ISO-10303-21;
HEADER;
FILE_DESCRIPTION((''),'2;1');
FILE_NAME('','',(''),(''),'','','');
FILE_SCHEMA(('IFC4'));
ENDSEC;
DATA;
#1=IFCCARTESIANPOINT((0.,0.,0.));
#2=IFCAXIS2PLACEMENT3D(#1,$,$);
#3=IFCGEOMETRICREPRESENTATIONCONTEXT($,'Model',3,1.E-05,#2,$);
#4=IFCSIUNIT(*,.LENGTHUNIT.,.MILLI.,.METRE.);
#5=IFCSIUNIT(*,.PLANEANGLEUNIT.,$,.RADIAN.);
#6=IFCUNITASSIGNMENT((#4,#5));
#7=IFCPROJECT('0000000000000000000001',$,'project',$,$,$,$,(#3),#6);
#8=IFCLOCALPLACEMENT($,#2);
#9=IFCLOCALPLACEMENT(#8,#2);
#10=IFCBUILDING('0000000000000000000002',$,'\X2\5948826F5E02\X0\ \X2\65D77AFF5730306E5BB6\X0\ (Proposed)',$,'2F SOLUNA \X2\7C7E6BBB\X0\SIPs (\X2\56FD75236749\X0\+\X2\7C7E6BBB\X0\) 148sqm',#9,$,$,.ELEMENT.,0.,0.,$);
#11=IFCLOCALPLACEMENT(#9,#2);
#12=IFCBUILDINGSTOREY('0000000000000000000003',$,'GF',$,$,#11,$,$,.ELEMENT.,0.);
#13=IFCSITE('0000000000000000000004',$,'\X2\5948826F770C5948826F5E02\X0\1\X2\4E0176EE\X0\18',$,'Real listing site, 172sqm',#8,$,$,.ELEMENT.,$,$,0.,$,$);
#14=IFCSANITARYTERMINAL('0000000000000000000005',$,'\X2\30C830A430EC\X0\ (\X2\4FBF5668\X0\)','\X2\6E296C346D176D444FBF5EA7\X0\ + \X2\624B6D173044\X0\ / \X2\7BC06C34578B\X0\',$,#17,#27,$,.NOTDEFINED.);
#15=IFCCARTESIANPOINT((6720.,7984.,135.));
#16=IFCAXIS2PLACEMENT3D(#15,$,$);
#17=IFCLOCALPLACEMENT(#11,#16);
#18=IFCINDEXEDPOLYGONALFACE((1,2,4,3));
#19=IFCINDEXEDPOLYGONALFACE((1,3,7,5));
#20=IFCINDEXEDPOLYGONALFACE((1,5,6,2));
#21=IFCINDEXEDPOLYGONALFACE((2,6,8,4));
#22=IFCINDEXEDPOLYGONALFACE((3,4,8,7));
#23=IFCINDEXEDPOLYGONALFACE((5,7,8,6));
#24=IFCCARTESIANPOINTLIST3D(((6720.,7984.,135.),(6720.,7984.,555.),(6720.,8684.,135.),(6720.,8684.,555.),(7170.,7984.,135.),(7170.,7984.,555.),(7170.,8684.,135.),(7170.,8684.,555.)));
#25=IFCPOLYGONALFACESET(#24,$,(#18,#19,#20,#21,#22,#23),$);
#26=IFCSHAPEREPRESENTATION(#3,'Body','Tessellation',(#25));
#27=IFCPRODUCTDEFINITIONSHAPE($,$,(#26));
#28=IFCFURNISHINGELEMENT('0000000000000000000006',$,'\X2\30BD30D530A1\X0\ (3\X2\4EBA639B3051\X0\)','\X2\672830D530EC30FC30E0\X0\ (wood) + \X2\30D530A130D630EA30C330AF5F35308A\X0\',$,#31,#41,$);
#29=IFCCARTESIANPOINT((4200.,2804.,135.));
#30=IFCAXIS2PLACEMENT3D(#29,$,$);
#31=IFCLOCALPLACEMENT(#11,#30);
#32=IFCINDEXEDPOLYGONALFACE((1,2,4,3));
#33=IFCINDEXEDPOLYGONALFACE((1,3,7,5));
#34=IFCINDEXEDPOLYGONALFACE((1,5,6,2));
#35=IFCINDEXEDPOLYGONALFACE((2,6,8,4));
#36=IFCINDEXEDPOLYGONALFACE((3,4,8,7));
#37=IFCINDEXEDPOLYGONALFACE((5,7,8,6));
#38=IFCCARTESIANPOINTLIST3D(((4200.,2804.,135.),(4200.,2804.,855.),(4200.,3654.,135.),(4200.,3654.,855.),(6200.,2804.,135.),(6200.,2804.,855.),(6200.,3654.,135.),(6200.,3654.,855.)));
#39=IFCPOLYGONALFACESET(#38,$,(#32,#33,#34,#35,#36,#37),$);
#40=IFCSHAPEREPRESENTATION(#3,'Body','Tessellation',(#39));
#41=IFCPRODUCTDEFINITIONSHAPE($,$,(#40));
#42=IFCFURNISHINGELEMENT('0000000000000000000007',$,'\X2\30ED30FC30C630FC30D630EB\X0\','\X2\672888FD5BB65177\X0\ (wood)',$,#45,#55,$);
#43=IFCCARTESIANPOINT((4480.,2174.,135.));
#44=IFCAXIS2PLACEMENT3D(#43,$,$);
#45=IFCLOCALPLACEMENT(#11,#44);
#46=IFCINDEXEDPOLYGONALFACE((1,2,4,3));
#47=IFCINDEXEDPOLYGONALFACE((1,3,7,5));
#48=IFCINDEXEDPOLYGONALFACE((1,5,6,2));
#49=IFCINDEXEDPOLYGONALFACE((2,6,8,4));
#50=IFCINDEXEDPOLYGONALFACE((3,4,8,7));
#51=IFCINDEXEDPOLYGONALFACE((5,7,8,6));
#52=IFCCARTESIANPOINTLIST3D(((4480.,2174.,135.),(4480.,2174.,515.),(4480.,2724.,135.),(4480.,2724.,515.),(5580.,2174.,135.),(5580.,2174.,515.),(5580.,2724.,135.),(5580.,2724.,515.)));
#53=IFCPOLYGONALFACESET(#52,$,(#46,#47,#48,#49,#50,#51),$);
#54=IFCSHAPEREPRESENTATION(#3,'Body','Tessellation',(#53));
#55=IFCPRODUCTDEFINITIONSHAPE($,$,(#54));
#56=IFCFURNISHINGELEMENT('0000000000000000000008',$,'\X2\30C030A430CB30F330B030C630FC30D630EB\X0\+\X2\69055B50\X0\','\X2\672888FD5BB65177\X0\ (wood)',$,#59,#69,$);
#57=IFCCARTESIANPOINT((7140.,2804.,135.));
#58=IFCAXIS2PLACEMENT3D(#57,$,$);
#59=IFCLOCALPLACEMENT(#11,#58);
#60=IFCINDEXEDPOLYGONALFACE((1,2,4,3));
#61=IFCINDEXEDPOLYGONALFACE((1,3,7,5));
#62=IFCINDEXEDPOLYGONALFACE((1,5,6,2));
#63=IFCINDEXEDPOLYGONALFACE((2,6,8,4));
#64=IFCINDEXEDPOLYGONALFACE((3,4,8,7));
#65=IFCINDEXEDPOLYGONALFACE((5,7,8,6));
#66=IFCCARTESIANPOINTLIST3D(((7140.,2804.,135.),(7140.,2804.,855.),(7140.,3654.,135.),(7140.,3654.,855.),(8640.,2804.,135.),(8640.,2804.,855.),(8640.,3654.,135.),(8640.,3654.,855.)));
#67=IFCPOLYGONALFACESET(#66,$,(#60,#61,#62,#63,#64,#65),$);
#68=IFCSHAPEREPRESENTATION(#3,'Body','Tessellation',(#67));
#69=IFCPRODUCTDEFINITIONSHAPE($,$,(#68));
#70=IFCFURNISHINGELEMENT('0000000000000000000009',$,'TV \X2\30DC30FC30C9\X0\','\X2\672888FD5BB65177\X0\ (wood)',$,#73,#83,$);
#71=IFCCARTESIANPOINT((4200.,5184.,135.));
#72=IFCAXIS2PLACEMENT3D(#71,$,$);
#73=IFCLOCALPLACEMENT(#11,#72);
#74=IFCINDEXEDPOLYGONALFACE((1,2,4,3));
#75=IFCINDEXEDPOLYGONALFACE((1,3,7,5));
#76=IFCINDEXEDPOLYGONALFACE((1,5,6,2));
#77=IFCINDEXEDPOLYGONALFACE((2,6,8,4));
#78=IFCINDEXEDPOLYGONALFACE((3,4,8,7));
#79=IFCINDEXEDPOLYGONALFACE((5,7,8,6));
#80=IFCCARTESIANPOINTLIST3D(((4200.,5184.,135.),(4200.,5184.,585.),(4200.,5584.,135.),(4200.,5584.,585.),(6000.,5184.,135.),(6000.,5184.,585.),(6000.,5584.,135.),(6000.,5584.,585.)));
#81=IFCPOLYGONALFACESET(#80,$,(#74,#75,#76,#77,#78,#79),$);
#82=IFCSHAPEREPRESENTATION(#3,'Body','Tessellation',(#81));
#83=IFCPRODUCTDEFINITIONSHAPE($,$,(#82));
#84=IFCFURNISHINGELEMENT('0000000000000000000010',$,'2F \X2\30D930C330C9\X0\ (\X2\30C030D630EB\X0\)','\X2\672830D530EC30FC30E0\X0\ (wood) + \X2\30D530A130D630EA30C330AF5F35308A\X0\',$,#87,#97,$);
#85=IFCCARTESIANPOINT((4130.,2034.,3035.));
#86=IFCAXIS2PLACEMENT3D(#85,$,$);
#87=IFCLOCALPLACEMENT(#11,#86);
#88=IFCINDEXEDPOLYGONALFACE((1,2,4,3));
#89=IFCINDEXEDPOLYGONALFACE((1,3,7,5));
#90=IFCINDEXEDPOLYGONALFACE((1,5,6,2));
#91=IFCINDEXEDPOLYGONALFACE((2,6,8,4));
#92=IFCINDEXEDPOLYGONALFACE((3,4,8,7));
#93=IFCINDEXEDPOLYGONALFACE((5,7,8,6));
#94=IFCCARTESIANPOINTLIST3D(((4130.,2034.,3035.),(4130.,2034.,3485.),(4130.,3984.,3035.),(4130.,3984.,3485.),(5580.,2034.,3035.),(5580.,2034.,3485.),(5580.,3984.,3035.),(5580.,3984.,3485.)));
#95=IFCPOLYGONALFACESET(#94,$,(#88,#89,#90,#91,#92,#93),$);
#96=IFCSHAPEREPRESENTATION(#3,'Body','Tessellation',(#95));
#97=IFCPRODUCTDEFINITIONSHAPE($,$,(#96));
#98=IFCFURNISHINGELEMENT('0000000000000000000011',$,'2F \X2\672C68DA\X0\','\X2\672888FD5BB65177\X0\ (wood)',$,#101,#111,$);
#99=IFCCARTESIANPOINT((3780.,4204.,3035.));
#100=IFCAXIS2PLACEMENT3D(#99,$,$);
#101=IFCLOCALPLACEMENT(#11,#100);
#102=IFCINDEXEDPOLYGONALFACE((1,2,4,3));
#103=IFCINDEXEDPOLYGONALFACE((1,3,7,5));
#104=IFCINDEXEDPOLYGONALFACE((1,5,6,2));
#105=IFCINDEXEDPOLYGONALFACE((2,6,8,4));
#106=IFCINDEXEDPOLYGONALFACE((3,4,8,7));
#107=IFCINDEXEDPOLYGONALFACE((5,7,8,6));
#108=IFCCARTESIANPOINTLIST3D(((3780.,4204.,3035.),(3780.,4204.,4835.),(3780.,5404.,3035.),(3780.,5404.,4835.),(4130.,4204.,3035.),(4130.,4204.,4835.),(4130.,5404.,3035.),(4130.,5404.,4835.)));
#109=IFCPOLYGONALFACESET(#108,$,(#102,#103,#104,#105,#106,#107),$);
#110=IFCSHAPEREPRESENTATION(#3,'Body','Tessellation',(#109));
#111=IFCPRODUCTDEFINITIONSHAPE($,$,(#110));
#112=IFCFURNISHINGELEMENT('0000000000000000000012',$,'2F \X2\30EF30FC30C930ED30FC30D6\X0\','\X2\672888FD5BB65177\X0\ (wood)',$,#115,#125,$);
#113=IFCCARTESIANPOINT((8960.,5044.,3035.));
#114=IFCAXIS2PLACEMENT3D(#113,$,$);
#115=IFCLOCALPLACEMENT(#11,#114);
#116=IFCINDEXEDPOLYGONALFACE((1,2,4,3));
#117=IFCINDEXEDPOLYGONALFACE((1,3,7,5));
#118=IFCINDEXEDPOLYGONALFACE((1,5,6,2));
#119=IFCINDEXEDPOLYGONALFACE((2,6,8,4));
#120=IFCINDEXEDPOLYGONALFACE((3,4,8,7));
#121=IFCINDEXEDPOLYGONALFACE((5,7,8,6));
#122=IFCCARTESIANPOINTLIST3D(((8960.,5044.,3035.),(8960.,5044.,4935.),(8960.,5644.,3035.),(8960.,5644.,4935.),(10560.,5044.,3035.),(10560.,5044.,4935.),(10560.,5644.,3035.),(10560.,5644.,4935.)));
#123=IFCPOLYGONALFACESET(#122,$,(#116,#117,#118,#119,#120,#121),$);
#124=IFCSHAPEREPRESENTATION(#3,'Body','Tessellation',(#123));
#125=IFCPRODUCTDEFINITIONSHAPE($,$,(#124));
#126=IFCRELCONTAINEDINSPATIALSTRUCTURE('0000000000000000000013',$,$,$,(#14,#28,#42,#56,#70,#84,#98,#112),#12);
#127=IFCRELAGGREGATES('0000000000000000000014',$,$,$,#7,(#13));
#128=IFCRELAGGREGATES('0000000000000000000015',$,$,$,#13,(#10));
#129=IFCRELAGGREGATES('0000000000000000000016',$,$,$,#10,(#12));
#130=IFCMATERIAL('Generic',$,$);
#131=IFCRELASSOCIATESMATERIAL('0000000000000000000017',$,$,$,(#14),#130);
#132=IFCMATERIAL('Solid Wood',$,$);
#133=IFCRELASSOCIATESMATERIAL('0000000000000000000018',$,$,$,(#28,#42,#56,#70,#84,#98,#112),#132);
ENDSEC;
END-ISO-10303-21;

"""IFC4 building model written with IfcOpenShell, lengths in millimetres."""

from ifc_helpers import new_model, si_unit, frame, frame_2d, origin, place, context, project, spatial, rectangle, extrude, material, element, save


model = new_model("IFC4")

# Units and contexts
model_context = context("Model", 3, precision=1e-05, world=origin())
ifc_project = project(units=[si_unit("LENGTHUNIT", "METRE", prefix="MILLI"), si_unit("PLANEANGLEUNIT", "RADIAN")], contexts=[model_context])

# Site, building, storey
site_placement = place(None, origin())
site = spatial("IfcSite", under=ifc_project, at=site_placement, Name="奈良県奈良市1丁目18", ObjectType="Real listing site, 172sqm", CompositionType="ELEMENT", RefElevation=0.0)
building_placement = place(site_placement, origin())
building = spatial("IfcBuilding", under=site, at=building_placement, Name="奈良市 旗竿地の家 (Proposed)", ObjectType="2F SOLUNA 籾殻SIPs (国産杉+籾殻) 148sqm", CompositionType="ELEMENT", ElevationOfRefHeight=0.0, ElevationOfTerrain=0.0)
storey_placement = place(building_placement, origin())
storey = spatial("IfcBuildingStorey", under=building, at=storey_placement, Name="GF", CompositionType="ELEMENT", Elevation=0.0)

# Shared definitions
ifc_material_1 = material(Name="Solid Wood")

# Shared definitions
ifc_material_2 = material(Name="Generic")

# Sanitary terminal
sanitary_terminal_1_placement = place(storey_placement, frame((6720.0, 7984.0, 135.0)))
element("IfcSanitaryTerminal", 1, at=sanitary_terminal_1_placement, inside=storey, material=ifc_material_2, Name="トイレ (便器)", Description="温水洗浄便座 + 手洗い / 節水型", PredefinedType="NOTDEFINED", context=model_context, shape_type="SweptSolid", body=[
    extrude(rectangle(XDim=450.0, YDim=700.0, at=frame_2d((225.0, 350.0))), frame((6720.0, 7984.0, 135.0)), (0.0, 0.0, 1.0), 420.0),
])

# Furnishing elements
furnishing_1_placement = place(storey_placement, frame((4200.0, 2804.0, 135.0)))
element("IfcFurnishingElement", 2, at=furnishing_1_placement, inside=storey, material=ifc_material_1, Name="ソファ (3人掛け)", Description="木フレーム (wood) + ファブリック張り", context=model_context, shape_type="SweptSolid", body=[
    extrude(rectangle(XDim=2000.0, YDim=850.0, at=frame_2d((1000.0, 425.0))), frame((4200.0, 2804.0, 135.0)), (0.0, 0.0, 1.0), 720.0),
])
furnishing_2_placement = place(storey_placement, frame((4480.0, 2174.0, 135.0)))
element("IfcFurnishingElement", 3, at=furnishing_2_placement, inside=storey, material=ifc_material_1, Name="ローテーブル", Description="木製家具 (wood)", context=model_context, shape_type="SweptSolid", body=[
    extrude(rectangle(XDim=1100.0, YDim=550.0, at=frame_2d((550.0, 275.0))), frame((4480.0, 2174.0, 135.0)), (0.0, 0.0, 1.0), 380.0),
])
furnishing_3_placement = place(storey_placement, frame((7140.0, 2804.0, 135.0)))
element("IfcFurnishingElement", 4, at=furnishing_3_placement, inside=storey, material=ifc_material_1, Name="ダイニングテーブル+椅子", Description="木製家具 (wood)", context=model_context, shape_type="SweptSolid", body=[
    extrude(rectangle(XDim=1500.0, YDim=850.0, at=frame_2d((750.0, 425.0))), frame((7140.0, 2804.0, 135.0)), (0.0, 0.0, 1.0), 720.0),
])
furnishing_4_placement = place(storey_placement, frame((4200.0, 5184.0, 135.0)))
element("IfcFurnishingElement", 5, at=furnishing_4_placement, inside=storey, material=ifc_material_1, Name="TV ボード", Description="木製家具 (wood)", context=model_context, shape_type="SweptSolid", body=[
    extrude(rectangle(XDim=1800.0, YDim=400.0, at=frame_2d((900.0, 200.0))), frame((4200.0, 5184.0, 135.0)), (0.0, 0.0, 1.0), 450.0),
])
furnishing_5_placement = place(storey_placement, frame((4130.0, 2034.0, 3035.0)))
element("IfcFurnishingElement", 6, at=furnishing_5_placement, inside=storey, material=ifc_material_1, Name="2F ベッド (ダブル)", Description="木フレーム (wood) + ファブリック張り", context=model_context, shape_type="SweptSolid", body=[
    extrude(rectangle(XDim=1450.0, YDim=1950.0, at=frame_2d((725.0, 975.0))), frame((4130.0, 2034.0, 3035.0)), (0.0, 0.0, 1.0), 450.0),
])
furnishing_6_placement = place(storey_placement, frame((3780.0, 4204.0, 3035.0)))
element("IfcFurnishingElement", 7, at=furnishing_6_placement, inside=storey, material=ifc_material_1, Name="2F 本棚", Description="木製家具 (wood)", context=model_context, shape_type="SweptSolid", body=[
    extrude(rectangle(XDim=350.0, YDim=1200.0, at=frame_2d((175.0, 600.0))), frame((3780.0, 4204.0, 3035.0)), (0.0, 0.0, 1.0), 1800.0),
])
furnishing_7_placement = place(storey_placement, frame((8960.0, 5044.0, 3035.0)))
element("IfcFurnishingElement", 8, at=furnishing_7_placement, inside=storey, material=ifc_material_1, Name="2F ワードローブ", Description="木製家具 (wood)", context=model_context, shape_type="SweptSolid", body=[
    extrude(rectangle(XDim=1600.0, YDim=600.0, at=frame_2d((800.0, 300.0))), frame((8960.0, 5044.0, 3035.0)), (0.0, 0.0, 1.0), 1900.0),
])

save(model, "model.ifc")
